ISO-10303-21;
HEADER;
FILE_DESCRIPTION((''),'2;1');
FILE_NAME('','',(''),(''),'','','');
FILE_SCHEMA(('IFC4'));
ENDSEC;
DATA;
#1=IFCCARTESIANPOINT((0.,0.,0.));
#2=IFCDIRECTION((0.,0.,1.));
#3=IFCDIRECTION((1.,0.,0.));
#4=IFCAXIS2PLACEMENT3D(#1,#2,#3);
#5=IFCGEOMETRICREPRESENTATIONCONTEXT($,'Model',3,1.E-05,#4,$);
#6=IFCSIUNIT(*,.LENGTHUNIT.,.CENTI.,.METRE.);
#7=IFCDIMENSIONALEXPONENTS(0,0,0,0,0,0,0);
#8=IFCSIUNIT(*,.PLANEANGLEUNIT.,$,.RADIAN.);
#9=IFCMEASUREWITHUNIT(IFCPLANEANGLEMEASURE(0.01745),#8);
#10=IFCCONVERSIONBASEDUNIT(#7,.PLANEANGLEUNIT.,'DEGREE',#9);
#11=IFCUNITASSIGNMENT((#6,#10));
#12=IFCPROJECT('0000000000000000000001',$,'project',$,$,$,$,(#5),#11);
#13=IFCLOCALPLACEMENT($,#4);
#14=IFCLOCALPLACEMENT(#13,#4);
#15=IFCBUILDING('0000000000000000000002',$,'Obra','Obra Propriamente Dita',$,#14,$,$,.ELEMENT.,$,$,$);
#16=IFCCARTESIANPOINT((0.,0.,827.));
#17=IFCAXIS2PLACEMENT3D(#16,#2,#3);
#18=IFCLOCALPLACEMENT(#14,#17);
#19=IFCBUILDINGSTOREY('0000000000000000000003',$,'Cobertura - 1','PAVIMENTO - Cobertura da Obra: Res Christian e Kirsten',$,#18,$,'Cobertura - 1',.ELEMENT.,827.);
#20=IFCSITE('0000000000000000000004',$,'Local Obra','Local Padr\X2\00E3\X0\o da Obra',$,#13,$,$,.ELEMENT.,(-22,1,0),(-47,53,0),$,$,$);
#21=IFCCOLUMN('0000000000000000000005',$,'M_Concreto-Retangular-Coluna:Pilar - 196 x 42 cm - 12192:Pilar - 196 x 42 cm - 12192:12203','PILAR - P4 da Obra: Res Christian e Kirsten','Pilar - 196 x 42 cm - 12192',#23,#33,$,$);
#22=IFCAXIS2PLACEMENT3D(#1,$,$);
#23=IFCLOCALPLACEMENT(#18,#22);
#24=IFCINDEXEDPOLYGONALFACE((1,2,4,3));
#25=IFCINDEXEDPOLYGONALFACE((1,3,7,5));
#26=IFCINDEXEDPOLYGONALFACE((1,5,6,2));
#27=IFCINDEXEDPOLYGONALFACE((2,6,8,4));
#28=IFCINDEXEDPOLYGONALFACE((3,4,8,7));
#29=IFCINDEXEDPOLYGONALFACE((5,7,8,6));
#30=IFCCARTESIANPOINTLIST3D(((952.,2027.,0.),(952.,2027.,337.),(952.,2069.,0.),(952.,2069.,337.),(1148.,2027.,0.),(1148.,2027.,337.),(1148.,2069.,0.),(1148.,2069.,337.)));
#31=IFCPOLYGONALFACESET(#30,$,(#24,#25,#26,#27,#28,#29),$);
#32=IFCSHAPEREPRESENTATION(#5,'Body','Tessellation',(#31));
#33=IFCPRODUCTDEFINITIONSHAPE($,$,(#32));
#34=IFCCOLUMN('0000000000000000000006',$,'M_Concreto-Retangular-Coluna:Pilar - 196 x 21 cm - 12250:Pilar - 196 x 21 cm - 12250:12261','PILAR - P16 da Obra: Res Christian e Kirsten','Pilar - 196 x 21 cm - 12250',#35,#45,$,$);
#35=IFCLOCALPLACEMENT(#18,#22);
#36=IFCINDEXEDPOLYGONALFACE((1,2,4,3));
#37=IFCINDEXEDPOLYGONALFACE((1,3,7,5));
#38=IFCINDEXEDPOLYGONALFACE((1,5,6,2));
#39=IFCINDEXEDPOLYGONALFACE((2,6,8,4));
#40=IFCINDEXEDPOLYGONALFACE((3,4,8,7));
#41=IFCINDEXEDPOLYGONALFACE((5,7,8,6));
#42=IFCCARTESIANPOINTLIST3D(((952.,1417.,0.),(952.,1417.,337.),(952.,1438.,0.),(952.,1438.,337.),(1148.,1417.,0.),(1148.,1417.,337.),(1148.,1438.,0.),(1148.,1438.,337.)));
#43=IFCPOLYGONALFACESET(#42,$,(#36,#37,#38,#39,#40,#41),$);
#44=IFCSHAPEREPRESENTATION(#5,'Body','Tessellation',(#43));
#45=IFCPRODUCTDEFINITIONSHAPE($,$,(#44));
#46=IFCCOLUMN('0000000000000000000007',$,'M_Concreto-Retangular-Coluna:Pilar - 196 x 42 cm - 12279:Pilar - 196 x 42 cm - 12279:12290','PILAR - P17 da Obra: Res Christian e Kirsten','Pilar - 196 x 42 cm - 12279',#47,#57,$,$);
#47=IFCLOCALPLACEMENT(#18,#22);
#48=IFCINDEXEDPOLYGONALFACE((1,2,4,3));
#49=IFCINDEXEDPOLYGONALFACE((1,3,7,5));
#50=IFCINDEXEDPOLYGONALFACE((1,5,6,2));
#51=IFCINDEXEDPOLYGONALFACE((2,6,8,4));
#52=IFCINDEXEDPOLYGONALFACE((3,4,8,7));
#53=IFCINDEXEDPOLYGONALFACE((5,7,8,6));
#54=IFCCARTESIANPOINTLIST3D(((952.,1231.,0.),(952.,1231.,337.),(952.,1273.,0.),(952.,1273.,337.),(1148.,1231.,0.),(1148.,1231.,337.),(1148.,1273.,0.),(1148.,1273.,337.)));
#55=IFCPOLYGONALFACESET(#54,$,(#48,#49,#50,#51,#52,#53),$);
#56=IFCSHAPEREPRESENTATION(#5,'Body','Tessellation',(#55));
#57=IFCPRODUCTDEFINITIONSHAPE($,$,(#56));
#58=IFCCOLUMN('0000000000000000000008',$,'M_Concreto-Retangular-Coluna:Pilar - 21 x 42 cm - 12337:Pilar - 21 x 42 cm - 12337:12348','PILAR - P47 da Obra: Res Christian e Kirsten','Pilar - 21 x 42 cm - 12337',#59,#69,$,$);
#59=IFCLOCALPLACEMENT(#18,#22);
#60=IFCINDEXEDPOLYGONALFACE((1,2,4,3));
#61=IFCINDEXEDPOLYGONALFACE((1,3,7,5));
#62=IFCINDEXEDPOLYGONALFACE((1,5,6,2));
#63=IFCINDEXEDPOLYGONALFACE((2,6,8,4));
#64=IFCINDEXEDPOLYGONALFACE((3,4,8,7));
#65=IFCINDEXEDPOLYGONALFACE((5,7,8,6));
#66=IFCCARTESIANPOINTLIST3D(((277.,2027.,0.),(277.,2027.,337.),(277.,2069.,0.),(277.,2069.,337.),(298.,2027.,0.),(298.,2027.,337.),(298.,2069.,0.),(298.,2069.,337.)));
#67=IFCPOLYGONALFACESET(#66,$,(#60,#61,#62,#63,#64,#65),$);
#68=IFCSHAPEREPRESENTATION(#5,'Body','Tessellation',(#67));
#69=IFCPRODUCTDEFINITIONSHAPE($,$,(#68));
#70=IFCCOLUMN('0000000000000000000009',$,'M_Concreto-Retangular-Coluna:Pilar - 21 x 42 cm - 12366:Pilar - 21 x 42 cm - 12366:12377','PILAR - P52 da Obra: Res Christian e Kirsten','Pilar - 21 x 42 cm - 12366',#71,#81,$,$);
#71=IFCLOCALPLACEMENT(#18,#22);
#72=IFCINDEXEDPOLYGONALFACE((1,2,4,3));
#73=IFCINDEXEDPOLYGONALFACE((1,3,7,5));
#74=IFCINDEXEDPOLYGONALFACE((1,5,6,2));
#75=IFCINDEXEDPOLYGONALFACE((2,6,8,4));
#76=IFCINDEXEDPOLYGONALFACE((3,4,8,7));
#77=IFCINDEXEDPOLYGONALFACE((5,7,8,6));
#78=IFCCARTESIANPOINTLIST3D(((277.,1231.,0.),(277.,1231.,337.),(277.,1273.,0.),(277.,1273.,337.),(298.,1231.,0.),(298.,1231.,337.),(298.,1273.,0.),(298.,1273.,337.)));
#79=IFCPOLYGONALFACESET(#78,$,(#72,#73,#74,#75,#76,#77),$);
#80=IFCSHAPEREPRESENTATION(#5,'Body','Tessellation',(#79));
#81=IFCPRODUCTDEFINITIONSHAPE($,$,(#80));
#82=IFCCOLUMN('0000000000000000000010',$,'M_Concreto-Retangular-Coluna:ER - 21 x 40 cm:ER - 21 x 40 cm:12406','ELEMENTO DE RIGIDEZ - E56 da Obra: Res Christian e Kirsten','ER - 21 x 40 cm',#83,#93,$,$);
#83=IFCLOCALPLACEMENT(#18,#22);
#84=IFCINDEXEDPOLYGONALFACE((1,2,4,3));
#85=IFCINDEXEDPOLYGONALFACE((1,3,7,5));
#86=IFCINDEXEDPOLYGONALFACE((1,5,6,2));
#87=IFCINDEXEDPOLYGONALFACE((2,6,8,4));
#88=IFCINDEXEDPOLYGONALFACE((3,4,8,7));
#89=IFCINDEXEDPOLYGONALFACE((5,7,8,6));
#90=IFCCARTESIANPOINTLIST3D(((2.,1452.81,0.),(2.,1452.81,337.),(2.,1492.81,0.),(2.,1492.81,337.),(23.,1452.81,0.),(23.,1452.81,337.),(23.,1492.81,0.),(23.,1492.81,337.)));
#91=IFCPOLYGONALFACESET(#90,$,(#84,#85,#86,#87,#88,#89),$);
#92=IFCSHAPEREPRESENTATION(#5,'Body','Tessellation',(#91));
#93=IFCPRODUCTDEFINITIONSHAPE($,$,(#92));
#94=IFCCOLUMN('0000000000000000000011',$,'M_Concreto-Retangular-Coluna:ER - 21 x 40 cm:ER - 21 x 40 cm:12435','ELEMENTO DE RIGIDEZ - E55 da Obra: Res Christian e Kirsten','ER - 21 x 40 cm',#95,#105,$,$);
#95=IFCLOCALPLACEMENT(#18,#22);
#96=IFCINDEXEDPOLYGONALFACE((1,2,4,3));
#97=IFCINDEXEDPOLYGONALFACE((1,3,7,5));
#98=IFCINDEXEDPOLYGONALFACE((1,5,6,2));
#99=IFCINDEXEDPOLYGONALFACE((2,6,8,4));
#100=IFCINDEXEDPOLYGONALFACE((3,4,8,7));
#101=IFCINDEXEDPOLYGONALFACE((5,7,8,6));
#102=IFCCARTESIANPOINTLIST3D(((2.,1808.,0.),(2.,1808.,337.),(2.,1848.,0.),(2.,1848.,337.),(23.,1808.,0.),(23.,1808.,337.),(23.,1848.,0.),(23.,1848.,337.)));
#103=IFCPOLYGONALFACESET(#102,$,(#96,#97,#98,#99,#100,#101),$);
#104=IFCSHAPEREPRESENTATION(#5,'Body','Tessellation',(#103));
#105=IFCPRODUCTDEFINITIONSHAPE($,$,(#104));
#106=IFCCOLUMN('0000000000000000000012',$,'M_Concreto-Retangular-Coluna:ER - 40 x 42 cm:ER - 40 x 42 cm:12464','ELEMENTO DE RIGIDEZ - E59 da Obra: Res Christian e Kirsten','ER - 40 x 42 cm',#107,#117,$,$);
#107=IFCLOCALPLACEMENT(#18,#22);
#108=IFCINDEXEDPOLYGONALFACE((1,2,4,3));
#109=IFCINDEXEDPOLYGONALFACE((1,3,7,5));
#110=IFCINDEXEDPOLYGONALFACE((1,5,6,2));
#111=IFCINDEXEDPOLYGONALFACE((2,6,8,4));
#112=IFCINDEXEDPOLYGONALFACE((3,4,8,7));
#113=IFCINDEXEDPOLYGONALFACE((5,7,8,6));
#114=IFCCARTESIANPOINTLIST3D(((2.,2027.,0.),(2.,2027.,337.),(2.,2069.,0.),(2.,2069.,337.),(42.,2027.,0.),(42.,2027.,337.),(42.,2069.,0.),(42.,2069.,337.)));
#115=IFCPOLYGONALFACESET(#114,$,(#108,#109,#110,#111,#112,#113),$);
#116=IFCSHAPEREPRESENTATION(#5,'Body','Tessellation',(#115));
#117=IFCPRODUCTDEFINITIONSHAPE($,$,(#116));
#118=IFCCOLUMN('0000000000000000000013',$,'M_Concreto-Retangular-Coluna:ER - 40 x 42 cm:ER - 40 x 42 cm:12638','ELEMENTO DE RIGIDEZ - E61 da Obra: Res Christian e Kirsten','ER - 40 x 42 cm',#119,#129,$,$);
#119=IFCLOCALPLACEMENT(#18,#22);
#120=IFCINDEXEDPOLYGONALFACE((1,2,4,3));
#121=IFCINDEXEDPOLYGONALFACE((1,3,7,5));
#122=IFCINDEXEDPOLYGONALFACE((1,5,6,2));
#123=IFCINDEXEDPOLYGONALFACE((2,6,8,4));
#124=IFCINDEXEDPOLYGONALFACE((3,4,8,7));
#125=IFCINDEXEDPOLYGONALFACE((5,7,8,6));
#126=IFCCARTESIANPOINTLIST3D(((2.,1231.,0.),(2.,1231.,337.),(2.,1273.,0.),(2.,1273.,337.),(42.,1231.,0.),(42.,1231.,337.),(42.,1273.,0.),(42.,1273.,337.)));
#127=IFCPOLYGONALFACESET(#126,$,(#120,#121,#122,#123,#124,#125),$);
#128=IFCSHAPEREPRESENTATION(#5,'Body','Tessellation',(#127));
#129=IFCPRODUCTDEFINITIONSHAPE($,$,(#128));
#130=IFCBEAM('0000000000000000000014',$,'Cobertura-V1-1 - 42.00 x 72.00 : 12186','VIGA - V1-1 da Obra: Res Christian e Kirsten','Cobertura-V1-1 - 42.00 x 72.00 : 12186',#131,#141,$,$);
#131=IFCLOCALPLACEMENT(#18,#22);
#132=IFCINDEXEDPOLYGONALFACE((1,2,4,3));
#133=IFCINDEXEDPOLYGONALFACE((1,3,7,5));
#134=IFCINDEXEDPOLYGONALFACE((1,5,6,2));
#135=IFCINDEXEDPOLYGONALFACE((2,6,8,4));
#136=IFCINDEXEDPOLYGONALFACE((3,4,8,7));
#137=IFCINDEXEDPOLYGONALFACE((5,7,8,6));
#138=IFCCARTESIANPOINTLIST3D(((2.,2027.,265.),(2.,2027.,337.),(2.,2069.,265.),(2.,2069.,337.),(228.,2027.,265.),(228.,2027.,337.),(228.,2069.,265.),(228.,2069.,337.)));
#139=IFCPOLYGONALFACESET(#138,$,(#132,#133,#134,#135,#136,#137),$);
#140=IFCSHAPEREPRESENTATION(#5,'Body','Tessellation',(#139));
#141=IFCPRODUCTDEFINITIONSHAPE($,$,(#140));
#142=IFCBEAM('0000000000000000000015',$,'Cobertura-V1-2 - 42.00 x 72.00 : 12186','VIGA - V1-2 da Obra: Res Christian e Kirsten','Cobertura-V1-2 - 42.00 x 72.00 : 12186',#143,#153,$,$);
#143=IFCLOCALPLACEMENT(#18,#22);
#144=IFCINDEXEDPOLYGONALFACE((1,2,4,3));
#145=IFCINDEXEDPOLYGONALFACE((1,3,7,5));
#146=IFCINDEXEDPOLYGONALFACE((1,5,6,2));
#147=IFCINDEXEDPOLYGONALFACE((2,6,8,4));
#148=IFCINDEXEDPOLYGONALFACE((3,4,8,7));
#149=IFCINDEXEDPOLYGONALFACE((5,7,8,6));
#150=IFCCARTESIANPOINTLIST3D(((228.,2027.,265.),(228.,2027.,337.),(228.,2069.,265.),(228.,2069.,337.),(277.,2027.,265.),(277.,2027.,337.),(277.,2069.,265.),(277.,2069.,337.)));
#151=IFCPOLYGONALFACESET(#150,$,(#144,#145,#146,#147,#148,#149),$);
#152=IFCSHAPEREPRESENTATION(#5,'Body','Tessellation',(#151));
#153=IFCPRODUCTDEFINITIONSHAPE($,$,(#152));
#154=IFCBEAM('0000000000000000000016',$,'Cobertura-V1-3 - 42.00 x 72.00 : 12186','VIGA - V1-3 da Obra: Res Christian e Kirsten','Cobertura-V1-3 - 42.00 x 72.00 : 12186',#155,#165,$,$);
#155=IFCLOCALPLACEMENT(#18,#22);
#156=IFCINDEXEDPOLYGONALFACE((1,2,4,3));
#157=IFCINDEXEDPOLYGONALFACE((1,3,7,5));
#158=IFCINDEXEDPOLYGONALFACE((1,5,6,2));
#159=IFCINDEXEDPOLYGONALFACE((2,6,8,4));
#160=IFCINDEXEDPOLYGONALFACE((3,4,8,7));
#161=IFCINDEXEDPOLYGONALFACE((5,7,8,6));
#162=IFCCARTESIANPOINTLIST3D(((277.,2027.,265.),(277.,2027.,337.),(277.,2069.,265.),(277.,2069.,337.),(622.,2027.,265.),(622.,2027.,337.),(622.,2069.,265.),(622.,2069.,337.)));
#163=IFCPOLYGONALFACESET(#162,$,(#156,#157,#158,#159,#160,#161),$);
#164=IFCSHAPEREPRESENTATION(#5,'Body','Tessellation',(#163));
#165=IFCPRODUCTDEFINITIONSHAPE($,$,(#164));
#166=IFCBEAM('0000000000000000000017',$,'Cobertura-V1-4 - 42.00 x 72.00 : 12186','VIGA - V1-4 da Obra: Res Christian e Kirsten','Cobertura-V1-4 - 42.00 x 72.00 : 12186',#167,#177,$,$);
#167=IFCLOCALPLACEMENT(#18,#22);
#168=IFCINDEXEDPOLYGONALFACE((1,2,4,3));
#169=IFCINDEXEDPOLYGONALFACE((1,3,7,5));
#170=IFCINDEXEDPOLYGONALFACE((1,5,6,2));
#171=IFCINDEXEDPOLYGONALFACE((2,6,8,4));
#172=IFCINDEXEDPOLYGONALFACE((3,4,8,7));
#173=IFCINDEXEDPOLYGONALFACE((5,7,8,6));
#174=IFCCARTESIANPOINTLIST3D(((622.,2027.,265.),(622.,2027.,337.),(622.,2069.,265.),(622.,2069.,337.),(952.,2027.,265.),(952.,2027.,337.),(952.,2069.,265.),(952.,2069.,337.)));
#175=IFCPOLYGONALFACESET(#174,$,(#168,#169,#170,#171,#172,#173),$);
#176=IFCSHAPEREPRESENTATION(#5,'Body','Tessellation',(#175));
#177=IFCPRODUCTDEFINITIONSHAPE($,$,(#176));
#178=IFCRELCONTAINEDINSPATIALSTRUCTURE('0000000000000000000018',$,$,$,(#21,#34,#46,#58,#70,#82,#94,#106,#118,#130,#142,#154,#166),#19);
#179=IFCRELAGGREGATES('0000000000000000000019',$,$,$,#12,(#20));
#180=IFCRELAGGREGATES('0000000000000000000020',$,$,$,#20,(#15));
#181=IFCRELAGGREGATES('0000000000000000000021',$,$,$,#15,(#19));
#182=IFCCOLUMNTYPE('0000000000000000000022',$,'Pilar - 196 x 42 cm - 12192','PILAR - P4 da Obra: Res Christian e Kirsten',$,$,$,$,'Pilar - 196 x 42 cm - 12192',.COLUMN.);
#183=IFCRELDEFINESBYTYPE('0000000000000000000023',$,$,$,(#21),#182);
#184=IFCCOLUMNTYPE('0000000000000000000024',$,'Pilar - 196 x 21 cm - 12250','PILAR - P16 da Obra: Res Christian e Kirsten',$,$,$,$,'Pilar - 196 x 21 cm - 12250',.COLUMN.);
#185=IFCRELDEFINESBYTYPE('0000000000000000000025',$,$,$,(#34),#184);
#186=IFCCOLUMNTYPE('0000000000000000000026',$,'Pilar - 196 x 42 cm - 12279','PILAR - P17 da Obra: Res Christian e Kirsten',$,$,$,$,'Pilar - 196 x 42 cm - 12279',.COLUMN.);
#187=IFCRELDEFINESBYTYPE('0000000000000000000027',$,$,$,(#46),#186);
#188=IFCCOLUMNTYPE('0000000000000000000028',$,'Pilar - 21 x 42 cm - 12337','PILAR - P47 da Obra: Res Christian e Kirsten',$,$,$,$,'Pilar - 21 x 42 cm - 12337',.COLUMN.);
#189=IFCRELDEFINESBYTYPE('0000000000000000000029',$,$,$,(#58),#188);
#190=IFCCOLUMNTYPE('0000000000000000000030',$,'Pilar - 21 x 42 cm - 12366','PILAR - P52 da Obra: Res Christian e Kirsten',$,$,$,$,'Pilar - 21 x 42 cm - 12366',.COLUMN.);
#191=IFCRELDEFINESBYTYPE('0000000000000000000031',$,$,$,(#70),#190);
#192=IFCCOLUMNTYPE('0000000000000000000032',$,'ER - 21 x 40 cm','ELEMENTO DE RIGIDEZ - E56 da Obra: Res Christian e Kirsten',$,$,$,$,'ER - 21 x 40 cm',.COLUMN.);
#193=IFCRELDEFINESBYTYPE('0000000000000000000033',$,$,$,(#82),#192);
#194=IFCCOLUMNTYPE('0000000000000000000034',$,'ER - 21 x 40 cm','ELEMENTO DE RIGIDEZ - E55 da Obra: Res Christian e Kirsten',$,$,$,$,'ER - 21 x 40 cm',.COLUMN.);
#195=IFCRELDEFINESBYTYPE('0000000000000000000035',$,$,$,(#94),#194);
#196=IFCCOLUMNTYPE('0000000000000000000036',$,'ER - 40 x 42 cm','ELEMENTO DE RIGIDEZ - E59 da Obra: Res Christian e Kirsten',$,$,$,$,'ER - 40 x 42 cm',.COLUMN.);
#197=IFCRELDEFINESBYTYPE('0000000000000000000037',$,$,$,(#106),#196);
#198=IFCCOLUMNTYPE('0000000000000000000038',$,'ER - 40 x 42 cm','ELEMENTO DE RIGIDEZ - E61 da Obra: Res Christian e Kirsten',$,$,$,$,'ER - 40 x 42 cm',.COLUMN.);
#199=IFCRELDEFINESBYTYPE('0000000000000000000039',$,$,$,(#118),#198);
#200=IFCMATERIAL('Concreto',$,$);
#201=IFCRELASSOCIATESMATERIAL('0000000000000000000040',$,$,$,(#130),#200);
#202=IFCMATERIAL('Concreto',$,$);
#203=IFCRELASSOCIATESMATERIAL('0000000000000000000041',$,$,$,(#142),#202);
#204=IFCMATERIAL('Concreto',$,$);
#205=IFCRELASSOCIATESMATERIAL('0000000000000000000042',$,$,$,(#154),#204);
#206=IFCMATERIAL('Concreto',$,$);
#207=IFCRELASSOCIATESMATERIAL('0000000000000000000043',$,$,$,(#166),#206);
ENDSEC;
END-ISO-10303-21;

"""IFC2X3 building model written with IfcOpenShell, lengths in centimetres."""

from ifc_helpers import new_model, entity, si_unit, converted_unit, frame, origin, origin_with_axes, origin_2d_with_axis, place, context, project, spatial, polyline, rectangle, outline, extrude, source, transform, mapped, material, type_object, type_shapes, element, save


model = new_model("IFC2X3")

# Units and contexts
model_context = context("Model", 3, precision=1e-05, world=origin_with_axes())
ifc_project = project(units=[si_unit("LENGTHUNIT", "METRE", prefix="CENTI"), converted_unit("PLANEANGLEUNIT", "DEGREE", entity("IfcPlaneAngleMeasure", 0.01745), si_unit("PLANEANGLEUNIT", "RADIAN"), dimensions=[0, 0, 0, 0, 0, 0, 0])], contexts=[model_context])

# Site, building, storey
site_placement = place(None, origin_with_axes())
site = spatial("IfcSite", under=ifc_project, at=site_placement, Name="Local Obra", Description="Local Padrão da Obra", CompositionType="ELEMENT", RefLatitude=(-22, 1, 0), RefLongitude=(-47, 53, 0))
building_placement = place(site_placement, origin_with_axes())
building = spatial("IfcBuilding", under=site, at=building_placement, Name="Obra", Description="Obra Propriamente Dita", CompositionType="ELEMENT")
storey_placement = place(building_placement, frame((0.0, 0.0, 827.0), z_axis=(0.0, 0.0, 1.0), x_axis=(1.0, 0.0, 0.0)))
storey = spatial("IfcBuildingStorey", under=building, at=storey_placement, Name="Cobertura - 1", Description="PAVIMENTO - Cobertura da Obra: Res Christian e Kirsten", LongName="Cobertura - 1", CompositionType="ELEMENT", Elevation=827.0)

# Columns
column_type_1 = type_object("IfcColumnType", Name="Pilar - 196 x 42 cm - 12192", Description="PILAR - P4 da Obra: Res Christian e Kirsten", ElementType="Pilar - 196 x 42 cm - 12192", PredefinedType="COLUMN")
shared_shape_1 = source(origin(), model_context, "Body", "SweptSolid", [
    extrude(rectangle(XDim=196.0, YDim=42.0, at=origin_2d_with_axis()), origin(), (0.0, 0.0, 1.0), 337.0),
])
type_shapes(column_type_1, [shared_shape_1])
column_1_placement = place(storey_placement, frame((1050.0, 2048.0, 0.0), z_axis=(0.0, 0.0, 1.0), x_axis=(1.0, 0.0, 0.0)))
element("IfcColumn", 1, at=column_1_placement, inside=storey, type_object=column_type_1, Name="M_Concreto-Retangular-Coluna:Pilar - 196 x 42 cm - 12192:Pilar - 196 x 42 cm - 12192:12203", Description="PILAR - P4 da Obra: Res Christian e Kirsten", ObjectType="Pilar - 196 x 42 cm - 12192", context=model_context, shape_type="MappedRepresentation", body=[
    mapped(shared_shape_1, transform((0.0, 0.0, 0.0), scale=1.0)),
])
column_type_2 = type_object("IfcColumnType", Name="Pilar - 196 x 21 cm - 12250", Description="PILAR - P16 da Obra: Res Christian e Kirsten", ElementType="Pilar - 196 x 21 cm - 12250", PredefinedType="COLUMN")
shared_shape_2 = source(origin(), model_context, "Body", "SweptSolid", [
    extrude(rectangle(XDim=196.0, YDim=21.0, at=origin_2d_with_axis()), origin(), (0.0, 0.0, 1.0), 337.0),
])
type_shapes(column_type_2, [shared_shape_2])
column_2_placement = place(storey_placement, frame((1050.0, 1427.5, 0.0), z_axis=(0.0, 0.0, 1.0), x_axis=(1.0, 0.0, 0.0)))
element("IfcColumn", 2, at=column_2_placement, inside=storey, type_object=column_type_2, Name="M_Concreto-Retangular-Coluna:Pilar - 196 x 21 cm - 12250:Pilar - 196 x 21 cm - 12250:12261", Description="PILAR - P16 da Obra: Res Christian e Kirsten", ObjectType="Pilar - 196 x 21 cm - 12250", context=model_context, shape_type="MappedRepresentation", body=[
    mapped(shared_shape_2, transform((0.0, 0.0, 0.0), scale=1.0)),
])
column_type_3 = type_object("IfcColumnType", Name="Pilar - 196 x 42 cm - 12279", Description="PILAR - P17 da Obra: Res Christian e Kirsten", ElementType="Pilar - 196 x 42 cm - 12279", PredefinedType="COLUMN")
shared_shape_3 = source(origin(), model_context, "Body", "SweptSolid", [
    extrude(rectangle(XDim=196.0, YDim=42.0, at=origin_2d_with_axis()), origin(), (0.0, 0.0, 1.0), 337.0),
])
type_shapes(column_type_3, [shared_shape_3])
column_3_placement = place(storey_placement, frame((1050.0, 1252.0, 0.0), z_axis=(0.0, 0.0, 1.0), x_axis=(1.0, 0.0, 0.0)))
element("IfcColumn", 3, at=column_3_placement, inside=storey, type_object=column_type_3, Name="M_Concreto-Retangular-Coluna:Pilar - 196 x 42 cm - 12279:Pilar - 196 x 42 cm - 12279:12290", Description="PILAR - P17 da Obra: Res Christian e Kirsten", ObjectType="Pilar - 196 x 42 cm - 12279", context=model_context, shape_type="MappedRepresentation", body=[
    mapped(shared_shape_3, transform((0.0, 0.0, 0.0), scale=1.0)),
])
column_type_4 = type_object("IfcColumnType", Name="Pilar - 21 x 42 cm - 12337", Description="PILAR - P47 da Obra: Res Christian e Kirsten", ElementType="Pilar - 21 x 42 cm - 12337", PredefinedType="COLUMN")
shared_shape_4 = source(origin(), model_context, "Body", "SweptSolid", [
    extrude(rectangle(XDim=21.0, YDim=42.0, at=origin_2d_with_axis()), origin(), (0.0, 0.0, 1.0), 337.0),
])
type_shapes(column_type_4, [shared_shape_4])
column_4_placement = place(storey_placement, frame((287.5, 2048.0, 0.0), z_axis=(0.0, 0.0, 1.0), x_axis=(1.0, 0.0, 0.0)))
element("IfcColumn", 4, at=column_4_placement, inside=storey, type_object=column_type_4, Name="M_Concreto-Retangular-Coluna:Pilar - 21 x 42 cm - 12337:Pilar - 21 x 42 cm - 12337:12348", Description="PILAR - P47 da Obra: Res Christian e Kirsten", ObjectType="Pilar - 21 x 42 cm - 12337", context=model_context, shape_type="MappedRepresentation", body=[
    mapped(shared_shape_4, transform((0.0, 0.0, 0.0), scale=1.0)),
])
column_type_5 = type_object("IfcColumnType", Name="Pilar - 21 x 42 cm - 12366", Description="PILAR - P52 da Obra: Res Christian e Kirsten", ElementType="Pilar - 21 x 42 cm - 12366", PredefinedType="COLUMN")
shared_shape_5 = source(origin(), model_context, "Body", "SweptSolid", [
    extrude(rectangle(XDim=21.0, YDim=42.0, at=origin_2d_with_axis()), origin(), (0.0, 0.0, 1.0), 337.0),
])
type_shapes(column_type_5, [shared_shape_5])
column_5_placement = place(storey_placement, frame((287.5, 1252.0, 0.0), z_axis=(0.0, 0.0, 1.0), x_axis=(1.0, 0.0, 0.0)))
element("IfcColumn", 5, at=column_5_placement, inside=storey, type_object=column_type_5, Name="M_Concreto-Retangular-Coluna:Pilar - 21 x 42 cm - 12366:Pilar - 21 x 42 cm - 12366:12377", Description="PILAR - P52 da Obra: Res Christian e Kirsten", ObjectType="Pilar - 21 x 42 cm - 12366", context=model_context, shape_type="MappedRepresentation", body=[
    mapped(shared_shape_5, transform((0.0, 0.0, 0.0), scale=1.0)),
])
column_type_6 = type_object("IfcColumnType", Name="ER - 21 x 40 cm", Description="ELEMENTO DE RIGIDEZ - E56 da Obra: Res Christian e Kirsten", ElementType="ER - 21 x 40 cm", PredefinedType="COLUMN")
shared_shape_6 = source(origin(), model_context, "Body", "SweptSolid", [
    extrude(rectangle(XDim=21.0, YDim=40.0, at=origin_2d_with_axis()), origin(), (0.0, 0.0, 1.0), 337.0),
])
type_shapes(column_type_6, [shared_shape_6])
column_6_placement = place(storey_placement, frame((12.5, 1472.81, 0.0), z_axis=(0.0, 0.0, 1.0), x_axis=(1.0, 0.0, 0.0)))
element("IfcColumn", 6, at=column_6_placement, inside=storey, type_object=column_type_6, Name="M_Concreto-Retangular-Coluna:ER - 21 x 40 cm:ER - 21 x 40 cm:12406", Description="ELEMENTO DE RIGIDEZ - E56 da Obra: Res Christian e Kirsten", ObjectType="ER - 21 x 40 cm", context=model_context, shape_type="MappedRepresentation", body=[
    mapped(shared_shape_6, transform((0.0, 0.0, 0.0), scale=1.0)),
])
column_type_7 = type_object("IfcColumnType", Name="ER - 21 x 40 cm", Description="ELEMENTO DE RIGIDEZ - E55 da Obra: Res Christian e Kirsten", ElementType="ER - 21 x 40 cm", PredefinedType="COLUMN")
shared_shape_7 = source(origin(), model_context, "Body", "SweptSolid", [
    extrude(rectangle(XDim=21.0, YDim=40.0, at=origin_2d_with_axis()), origin(), (0.0, 0.0, 1.0), 337.0),
])
type_shapes(column_type_7, [shared_shape_7])
column_7_placement = place(storey_placement, frame((12.5, 1828.0, 0.0), z_axis=(0.0, 0.0, 1.0), x_axis=(1.0, 0.0, 0.0)))
element("IfcColumn", 7, at=column_7_placement, inside=storey, type_object=column_type_7, Name="M_Concreto-Retangular-Coluna:ER - 21 x 40 cm:ER - 21 x 40 cm:12435", Description="ELEMENTO DE RIGIDEZ - E55 da Obra: Res Christian e Kirsten", ObjectType="ER - 21 x 40 cm", context=model_context, shape_type="MappedRepresentation", body=[
    mapped(shared_shape_7, transform((0.0, 0.0, 0.0), scale=1.0)),
])
column_type_8 = type_object("IfcColumnType", Name="ER - 40 x 42 cm", Description="ELEMENTO DE RIGIDEZ - E59 da Obra: Res Christian e Kirsten", ElementType="ER - 40 x 42 cm", PredefinedType="COLUMN")
shared_shape_8 = source(origin(), model_context, "Body", "SweptSolid", [
    extrude(rectangle(XDim=40.0, YDim=42.0, at=origin_2d_with_axis()), origin(), (0.0, 0.0, 1.0), 337.0),
])
type_shapes(column_type_8, [shared_shape_8])
column_8_placement = place(storey_placement, frame((22.0, 2048.0, 0.0), z_axis=(0.0, 0.0, 1.0), x_axis=(1.0, 0.0, 0.0)))
element("IfcColumn", 8, at=column_8_placement, inside=storey, type_object=column_type_8, Name="M_Concreto-Retangular-Coluna:ER - 40 x 42 cm:ER - 40 x 42 cm:12464", Description="ELEMENTO DE RIGIDEZ - E59 da Obra: Res Christian e Kirsten", ObjectType="ER - 40 x 42 cm", context=model_context, shape_type="MappedRepresentation", body=[
    mapped(shared_shape_8, transform((0.0, 0.0, 0.0), scale=1.0)),
])
column_type_9 = type_object("IfcColumnType", Name="ER - 40 x 42 cm", Description="ELEMENTO DE RIGIDEZ - E61 da Obra: Res Christian e Kirsten", ElementType="ER - 40 x 42 cm", PredefinedType="COLUMN")
shared_shape_9 = source(origin(), model_context, "Body", "SweptSolid", [
    extrude(rectangle(XDim=40.0, YDim=42.0, at=origin_2d_with_axis()), origin(), (0.0, 0.0, 1.0), 337.0),
])
type_shapes(column_type_9, [shared_shape_9])
column_9_placement = place(storey_placement, frame((22.0, 1252.0, 0.0), z_axis=(0.0, 0.0, 1.0), x_axis=(1.0, 0.0, 0.0)))
element("IfcColumn", 9, at=column_9_placement, inside=storey, type_object=column_type_9, Name="M_Concreto-Retangular-Coluna:ER - 40 x 42 cm:ER - 40 x 42 cm:12638", Description="ELEMENTO DE RIGIDEZ - E61 da Obra: Res Christian e Kirsten", ObjectType="ER - 40 x 42 cm", context=model_context, shape_type="MappedRepresentation", body=[
    mapped(shared_shape_9, transform((0.0, 0.0, 0.0), scale=1.0)),
])

# Beams
ifc_material_1 = material(Name="Concreto")
beam_1_placement = place(storey_placement, frame((2.0, 2048.0, 337.0), z_axis=(1.0, 0.0, 0.0), x_axis=(0.0, -1.0, 0.0)))
element("IfcBeam", 10, at=beam_1_placement, inside=storey, material=ifc_material_1, Name="Cobertura-V1-1 - 42.00 x 72.00 : 12186", Description="VIGA - V1-1 da Obra: Res Christian e Kirsten", ObjectType="Cobertura-V1-1 - 42.00 x 72.00 : 12186", context=model_context, shape_type="SweptSolid", body=[
    extrude(outline(polyline([(-21.0, 0.0), (21.0, 0.0), (21.0, 72.0), (-21.0, 72.0), (-21.0, 0.0)])), origin_with_axes(), (0.0, 0.0, 1.0), 226.0),
])
ifc_material_2 = material(Name="Concreto")
beam_2_placement = place(storey_placement, frame((228.0, 2048.0, 337.0), z_axis=(1.0, 0.0, 0.0), x_axis=(0.0, -1.0, 0.0)))
element("IfcBeam", 11, at=beam_2_placement, inside=storey, material=ifc_material_2, Name="Cobertura-V1-2 - 42.00 x 72.00 : 12186", Description="VIGA - V1-2 da Obra: Res Christian e Kirsten", ObjectType="Cobertura-V1-2 - 42.00 x 72.00 : 12186", context=model_context, shape_type="SweptSolid", body=[
    extrude(outline(polyline([(-21.0, 0.0), (21.0, 0.0), (21.0, 72.0), (-21.0, 72.0), (-21.0, 0.0)])), origin_with_axes(), (0.0, 0.0, 1.0), 49.0),
])
ifc_material_3 = material(Name="Concreto")
beam_3_placement = place(storey_placement, frame((277.0, 2048.0, 337.0), z_axis=(1.0, 0.0, 0.0), x_axis=(0.0, -1.0, 0.0)))
element("IfcBeam", 12, at=beam_3_placement, inside=storey, material=ifc_material_3, Name="Cobertura-V1-3 - 42.00 x 72.00 : 12186", Description="VIGA - V1-3 da Obra: Res Christian e Kirsten", ObjectType="Cobertura-V1-3 - 42.00 x 72.00 : 12186", context=model_context, shape_type="SweptSolid", body=[
    extrude(outline(polyline([(-21.0, 0.0), (21.0, 0.0), (21.0, 72.0), (-21.0, 72.0), (-21.0, 0.0)])), origin_with_axes(), (0.0, 0.0, 1.0), 345.0),
])
ifc_material_4 = material(Name="Concreto")
beam_4_placement = place(storey_placement, frame((622.0, 2048.0, 337.0), z_axis=(1.0, 0.0, 0.0), x_axis=(0.0, -1.0, 0.0)))
element("IfcBeam", 13, at=beam_4_placement, inside=storey, material=ifc_material_4, Name="Cobertura-V1-4 - 42.00 x 72.00 : 12186", Description="VIGA - V1-4 da Obra: Res Christian e Kirsten", ObjectType="Cobertura-V1-4 - 42.00 x 72.00 : 12186", context=model_context, shape_type="SweptSolid", body=[
    extrude(outline(polyline([(-21.0, 0.0), (21.0, 0.0), (21.0, 72.0), (-21.0, 72.0), (-21.0, 0.0)])), origin_with_axes(), (0.0, 0.0, 1.0), 330.0),
])

save(model, "model.ifc")
